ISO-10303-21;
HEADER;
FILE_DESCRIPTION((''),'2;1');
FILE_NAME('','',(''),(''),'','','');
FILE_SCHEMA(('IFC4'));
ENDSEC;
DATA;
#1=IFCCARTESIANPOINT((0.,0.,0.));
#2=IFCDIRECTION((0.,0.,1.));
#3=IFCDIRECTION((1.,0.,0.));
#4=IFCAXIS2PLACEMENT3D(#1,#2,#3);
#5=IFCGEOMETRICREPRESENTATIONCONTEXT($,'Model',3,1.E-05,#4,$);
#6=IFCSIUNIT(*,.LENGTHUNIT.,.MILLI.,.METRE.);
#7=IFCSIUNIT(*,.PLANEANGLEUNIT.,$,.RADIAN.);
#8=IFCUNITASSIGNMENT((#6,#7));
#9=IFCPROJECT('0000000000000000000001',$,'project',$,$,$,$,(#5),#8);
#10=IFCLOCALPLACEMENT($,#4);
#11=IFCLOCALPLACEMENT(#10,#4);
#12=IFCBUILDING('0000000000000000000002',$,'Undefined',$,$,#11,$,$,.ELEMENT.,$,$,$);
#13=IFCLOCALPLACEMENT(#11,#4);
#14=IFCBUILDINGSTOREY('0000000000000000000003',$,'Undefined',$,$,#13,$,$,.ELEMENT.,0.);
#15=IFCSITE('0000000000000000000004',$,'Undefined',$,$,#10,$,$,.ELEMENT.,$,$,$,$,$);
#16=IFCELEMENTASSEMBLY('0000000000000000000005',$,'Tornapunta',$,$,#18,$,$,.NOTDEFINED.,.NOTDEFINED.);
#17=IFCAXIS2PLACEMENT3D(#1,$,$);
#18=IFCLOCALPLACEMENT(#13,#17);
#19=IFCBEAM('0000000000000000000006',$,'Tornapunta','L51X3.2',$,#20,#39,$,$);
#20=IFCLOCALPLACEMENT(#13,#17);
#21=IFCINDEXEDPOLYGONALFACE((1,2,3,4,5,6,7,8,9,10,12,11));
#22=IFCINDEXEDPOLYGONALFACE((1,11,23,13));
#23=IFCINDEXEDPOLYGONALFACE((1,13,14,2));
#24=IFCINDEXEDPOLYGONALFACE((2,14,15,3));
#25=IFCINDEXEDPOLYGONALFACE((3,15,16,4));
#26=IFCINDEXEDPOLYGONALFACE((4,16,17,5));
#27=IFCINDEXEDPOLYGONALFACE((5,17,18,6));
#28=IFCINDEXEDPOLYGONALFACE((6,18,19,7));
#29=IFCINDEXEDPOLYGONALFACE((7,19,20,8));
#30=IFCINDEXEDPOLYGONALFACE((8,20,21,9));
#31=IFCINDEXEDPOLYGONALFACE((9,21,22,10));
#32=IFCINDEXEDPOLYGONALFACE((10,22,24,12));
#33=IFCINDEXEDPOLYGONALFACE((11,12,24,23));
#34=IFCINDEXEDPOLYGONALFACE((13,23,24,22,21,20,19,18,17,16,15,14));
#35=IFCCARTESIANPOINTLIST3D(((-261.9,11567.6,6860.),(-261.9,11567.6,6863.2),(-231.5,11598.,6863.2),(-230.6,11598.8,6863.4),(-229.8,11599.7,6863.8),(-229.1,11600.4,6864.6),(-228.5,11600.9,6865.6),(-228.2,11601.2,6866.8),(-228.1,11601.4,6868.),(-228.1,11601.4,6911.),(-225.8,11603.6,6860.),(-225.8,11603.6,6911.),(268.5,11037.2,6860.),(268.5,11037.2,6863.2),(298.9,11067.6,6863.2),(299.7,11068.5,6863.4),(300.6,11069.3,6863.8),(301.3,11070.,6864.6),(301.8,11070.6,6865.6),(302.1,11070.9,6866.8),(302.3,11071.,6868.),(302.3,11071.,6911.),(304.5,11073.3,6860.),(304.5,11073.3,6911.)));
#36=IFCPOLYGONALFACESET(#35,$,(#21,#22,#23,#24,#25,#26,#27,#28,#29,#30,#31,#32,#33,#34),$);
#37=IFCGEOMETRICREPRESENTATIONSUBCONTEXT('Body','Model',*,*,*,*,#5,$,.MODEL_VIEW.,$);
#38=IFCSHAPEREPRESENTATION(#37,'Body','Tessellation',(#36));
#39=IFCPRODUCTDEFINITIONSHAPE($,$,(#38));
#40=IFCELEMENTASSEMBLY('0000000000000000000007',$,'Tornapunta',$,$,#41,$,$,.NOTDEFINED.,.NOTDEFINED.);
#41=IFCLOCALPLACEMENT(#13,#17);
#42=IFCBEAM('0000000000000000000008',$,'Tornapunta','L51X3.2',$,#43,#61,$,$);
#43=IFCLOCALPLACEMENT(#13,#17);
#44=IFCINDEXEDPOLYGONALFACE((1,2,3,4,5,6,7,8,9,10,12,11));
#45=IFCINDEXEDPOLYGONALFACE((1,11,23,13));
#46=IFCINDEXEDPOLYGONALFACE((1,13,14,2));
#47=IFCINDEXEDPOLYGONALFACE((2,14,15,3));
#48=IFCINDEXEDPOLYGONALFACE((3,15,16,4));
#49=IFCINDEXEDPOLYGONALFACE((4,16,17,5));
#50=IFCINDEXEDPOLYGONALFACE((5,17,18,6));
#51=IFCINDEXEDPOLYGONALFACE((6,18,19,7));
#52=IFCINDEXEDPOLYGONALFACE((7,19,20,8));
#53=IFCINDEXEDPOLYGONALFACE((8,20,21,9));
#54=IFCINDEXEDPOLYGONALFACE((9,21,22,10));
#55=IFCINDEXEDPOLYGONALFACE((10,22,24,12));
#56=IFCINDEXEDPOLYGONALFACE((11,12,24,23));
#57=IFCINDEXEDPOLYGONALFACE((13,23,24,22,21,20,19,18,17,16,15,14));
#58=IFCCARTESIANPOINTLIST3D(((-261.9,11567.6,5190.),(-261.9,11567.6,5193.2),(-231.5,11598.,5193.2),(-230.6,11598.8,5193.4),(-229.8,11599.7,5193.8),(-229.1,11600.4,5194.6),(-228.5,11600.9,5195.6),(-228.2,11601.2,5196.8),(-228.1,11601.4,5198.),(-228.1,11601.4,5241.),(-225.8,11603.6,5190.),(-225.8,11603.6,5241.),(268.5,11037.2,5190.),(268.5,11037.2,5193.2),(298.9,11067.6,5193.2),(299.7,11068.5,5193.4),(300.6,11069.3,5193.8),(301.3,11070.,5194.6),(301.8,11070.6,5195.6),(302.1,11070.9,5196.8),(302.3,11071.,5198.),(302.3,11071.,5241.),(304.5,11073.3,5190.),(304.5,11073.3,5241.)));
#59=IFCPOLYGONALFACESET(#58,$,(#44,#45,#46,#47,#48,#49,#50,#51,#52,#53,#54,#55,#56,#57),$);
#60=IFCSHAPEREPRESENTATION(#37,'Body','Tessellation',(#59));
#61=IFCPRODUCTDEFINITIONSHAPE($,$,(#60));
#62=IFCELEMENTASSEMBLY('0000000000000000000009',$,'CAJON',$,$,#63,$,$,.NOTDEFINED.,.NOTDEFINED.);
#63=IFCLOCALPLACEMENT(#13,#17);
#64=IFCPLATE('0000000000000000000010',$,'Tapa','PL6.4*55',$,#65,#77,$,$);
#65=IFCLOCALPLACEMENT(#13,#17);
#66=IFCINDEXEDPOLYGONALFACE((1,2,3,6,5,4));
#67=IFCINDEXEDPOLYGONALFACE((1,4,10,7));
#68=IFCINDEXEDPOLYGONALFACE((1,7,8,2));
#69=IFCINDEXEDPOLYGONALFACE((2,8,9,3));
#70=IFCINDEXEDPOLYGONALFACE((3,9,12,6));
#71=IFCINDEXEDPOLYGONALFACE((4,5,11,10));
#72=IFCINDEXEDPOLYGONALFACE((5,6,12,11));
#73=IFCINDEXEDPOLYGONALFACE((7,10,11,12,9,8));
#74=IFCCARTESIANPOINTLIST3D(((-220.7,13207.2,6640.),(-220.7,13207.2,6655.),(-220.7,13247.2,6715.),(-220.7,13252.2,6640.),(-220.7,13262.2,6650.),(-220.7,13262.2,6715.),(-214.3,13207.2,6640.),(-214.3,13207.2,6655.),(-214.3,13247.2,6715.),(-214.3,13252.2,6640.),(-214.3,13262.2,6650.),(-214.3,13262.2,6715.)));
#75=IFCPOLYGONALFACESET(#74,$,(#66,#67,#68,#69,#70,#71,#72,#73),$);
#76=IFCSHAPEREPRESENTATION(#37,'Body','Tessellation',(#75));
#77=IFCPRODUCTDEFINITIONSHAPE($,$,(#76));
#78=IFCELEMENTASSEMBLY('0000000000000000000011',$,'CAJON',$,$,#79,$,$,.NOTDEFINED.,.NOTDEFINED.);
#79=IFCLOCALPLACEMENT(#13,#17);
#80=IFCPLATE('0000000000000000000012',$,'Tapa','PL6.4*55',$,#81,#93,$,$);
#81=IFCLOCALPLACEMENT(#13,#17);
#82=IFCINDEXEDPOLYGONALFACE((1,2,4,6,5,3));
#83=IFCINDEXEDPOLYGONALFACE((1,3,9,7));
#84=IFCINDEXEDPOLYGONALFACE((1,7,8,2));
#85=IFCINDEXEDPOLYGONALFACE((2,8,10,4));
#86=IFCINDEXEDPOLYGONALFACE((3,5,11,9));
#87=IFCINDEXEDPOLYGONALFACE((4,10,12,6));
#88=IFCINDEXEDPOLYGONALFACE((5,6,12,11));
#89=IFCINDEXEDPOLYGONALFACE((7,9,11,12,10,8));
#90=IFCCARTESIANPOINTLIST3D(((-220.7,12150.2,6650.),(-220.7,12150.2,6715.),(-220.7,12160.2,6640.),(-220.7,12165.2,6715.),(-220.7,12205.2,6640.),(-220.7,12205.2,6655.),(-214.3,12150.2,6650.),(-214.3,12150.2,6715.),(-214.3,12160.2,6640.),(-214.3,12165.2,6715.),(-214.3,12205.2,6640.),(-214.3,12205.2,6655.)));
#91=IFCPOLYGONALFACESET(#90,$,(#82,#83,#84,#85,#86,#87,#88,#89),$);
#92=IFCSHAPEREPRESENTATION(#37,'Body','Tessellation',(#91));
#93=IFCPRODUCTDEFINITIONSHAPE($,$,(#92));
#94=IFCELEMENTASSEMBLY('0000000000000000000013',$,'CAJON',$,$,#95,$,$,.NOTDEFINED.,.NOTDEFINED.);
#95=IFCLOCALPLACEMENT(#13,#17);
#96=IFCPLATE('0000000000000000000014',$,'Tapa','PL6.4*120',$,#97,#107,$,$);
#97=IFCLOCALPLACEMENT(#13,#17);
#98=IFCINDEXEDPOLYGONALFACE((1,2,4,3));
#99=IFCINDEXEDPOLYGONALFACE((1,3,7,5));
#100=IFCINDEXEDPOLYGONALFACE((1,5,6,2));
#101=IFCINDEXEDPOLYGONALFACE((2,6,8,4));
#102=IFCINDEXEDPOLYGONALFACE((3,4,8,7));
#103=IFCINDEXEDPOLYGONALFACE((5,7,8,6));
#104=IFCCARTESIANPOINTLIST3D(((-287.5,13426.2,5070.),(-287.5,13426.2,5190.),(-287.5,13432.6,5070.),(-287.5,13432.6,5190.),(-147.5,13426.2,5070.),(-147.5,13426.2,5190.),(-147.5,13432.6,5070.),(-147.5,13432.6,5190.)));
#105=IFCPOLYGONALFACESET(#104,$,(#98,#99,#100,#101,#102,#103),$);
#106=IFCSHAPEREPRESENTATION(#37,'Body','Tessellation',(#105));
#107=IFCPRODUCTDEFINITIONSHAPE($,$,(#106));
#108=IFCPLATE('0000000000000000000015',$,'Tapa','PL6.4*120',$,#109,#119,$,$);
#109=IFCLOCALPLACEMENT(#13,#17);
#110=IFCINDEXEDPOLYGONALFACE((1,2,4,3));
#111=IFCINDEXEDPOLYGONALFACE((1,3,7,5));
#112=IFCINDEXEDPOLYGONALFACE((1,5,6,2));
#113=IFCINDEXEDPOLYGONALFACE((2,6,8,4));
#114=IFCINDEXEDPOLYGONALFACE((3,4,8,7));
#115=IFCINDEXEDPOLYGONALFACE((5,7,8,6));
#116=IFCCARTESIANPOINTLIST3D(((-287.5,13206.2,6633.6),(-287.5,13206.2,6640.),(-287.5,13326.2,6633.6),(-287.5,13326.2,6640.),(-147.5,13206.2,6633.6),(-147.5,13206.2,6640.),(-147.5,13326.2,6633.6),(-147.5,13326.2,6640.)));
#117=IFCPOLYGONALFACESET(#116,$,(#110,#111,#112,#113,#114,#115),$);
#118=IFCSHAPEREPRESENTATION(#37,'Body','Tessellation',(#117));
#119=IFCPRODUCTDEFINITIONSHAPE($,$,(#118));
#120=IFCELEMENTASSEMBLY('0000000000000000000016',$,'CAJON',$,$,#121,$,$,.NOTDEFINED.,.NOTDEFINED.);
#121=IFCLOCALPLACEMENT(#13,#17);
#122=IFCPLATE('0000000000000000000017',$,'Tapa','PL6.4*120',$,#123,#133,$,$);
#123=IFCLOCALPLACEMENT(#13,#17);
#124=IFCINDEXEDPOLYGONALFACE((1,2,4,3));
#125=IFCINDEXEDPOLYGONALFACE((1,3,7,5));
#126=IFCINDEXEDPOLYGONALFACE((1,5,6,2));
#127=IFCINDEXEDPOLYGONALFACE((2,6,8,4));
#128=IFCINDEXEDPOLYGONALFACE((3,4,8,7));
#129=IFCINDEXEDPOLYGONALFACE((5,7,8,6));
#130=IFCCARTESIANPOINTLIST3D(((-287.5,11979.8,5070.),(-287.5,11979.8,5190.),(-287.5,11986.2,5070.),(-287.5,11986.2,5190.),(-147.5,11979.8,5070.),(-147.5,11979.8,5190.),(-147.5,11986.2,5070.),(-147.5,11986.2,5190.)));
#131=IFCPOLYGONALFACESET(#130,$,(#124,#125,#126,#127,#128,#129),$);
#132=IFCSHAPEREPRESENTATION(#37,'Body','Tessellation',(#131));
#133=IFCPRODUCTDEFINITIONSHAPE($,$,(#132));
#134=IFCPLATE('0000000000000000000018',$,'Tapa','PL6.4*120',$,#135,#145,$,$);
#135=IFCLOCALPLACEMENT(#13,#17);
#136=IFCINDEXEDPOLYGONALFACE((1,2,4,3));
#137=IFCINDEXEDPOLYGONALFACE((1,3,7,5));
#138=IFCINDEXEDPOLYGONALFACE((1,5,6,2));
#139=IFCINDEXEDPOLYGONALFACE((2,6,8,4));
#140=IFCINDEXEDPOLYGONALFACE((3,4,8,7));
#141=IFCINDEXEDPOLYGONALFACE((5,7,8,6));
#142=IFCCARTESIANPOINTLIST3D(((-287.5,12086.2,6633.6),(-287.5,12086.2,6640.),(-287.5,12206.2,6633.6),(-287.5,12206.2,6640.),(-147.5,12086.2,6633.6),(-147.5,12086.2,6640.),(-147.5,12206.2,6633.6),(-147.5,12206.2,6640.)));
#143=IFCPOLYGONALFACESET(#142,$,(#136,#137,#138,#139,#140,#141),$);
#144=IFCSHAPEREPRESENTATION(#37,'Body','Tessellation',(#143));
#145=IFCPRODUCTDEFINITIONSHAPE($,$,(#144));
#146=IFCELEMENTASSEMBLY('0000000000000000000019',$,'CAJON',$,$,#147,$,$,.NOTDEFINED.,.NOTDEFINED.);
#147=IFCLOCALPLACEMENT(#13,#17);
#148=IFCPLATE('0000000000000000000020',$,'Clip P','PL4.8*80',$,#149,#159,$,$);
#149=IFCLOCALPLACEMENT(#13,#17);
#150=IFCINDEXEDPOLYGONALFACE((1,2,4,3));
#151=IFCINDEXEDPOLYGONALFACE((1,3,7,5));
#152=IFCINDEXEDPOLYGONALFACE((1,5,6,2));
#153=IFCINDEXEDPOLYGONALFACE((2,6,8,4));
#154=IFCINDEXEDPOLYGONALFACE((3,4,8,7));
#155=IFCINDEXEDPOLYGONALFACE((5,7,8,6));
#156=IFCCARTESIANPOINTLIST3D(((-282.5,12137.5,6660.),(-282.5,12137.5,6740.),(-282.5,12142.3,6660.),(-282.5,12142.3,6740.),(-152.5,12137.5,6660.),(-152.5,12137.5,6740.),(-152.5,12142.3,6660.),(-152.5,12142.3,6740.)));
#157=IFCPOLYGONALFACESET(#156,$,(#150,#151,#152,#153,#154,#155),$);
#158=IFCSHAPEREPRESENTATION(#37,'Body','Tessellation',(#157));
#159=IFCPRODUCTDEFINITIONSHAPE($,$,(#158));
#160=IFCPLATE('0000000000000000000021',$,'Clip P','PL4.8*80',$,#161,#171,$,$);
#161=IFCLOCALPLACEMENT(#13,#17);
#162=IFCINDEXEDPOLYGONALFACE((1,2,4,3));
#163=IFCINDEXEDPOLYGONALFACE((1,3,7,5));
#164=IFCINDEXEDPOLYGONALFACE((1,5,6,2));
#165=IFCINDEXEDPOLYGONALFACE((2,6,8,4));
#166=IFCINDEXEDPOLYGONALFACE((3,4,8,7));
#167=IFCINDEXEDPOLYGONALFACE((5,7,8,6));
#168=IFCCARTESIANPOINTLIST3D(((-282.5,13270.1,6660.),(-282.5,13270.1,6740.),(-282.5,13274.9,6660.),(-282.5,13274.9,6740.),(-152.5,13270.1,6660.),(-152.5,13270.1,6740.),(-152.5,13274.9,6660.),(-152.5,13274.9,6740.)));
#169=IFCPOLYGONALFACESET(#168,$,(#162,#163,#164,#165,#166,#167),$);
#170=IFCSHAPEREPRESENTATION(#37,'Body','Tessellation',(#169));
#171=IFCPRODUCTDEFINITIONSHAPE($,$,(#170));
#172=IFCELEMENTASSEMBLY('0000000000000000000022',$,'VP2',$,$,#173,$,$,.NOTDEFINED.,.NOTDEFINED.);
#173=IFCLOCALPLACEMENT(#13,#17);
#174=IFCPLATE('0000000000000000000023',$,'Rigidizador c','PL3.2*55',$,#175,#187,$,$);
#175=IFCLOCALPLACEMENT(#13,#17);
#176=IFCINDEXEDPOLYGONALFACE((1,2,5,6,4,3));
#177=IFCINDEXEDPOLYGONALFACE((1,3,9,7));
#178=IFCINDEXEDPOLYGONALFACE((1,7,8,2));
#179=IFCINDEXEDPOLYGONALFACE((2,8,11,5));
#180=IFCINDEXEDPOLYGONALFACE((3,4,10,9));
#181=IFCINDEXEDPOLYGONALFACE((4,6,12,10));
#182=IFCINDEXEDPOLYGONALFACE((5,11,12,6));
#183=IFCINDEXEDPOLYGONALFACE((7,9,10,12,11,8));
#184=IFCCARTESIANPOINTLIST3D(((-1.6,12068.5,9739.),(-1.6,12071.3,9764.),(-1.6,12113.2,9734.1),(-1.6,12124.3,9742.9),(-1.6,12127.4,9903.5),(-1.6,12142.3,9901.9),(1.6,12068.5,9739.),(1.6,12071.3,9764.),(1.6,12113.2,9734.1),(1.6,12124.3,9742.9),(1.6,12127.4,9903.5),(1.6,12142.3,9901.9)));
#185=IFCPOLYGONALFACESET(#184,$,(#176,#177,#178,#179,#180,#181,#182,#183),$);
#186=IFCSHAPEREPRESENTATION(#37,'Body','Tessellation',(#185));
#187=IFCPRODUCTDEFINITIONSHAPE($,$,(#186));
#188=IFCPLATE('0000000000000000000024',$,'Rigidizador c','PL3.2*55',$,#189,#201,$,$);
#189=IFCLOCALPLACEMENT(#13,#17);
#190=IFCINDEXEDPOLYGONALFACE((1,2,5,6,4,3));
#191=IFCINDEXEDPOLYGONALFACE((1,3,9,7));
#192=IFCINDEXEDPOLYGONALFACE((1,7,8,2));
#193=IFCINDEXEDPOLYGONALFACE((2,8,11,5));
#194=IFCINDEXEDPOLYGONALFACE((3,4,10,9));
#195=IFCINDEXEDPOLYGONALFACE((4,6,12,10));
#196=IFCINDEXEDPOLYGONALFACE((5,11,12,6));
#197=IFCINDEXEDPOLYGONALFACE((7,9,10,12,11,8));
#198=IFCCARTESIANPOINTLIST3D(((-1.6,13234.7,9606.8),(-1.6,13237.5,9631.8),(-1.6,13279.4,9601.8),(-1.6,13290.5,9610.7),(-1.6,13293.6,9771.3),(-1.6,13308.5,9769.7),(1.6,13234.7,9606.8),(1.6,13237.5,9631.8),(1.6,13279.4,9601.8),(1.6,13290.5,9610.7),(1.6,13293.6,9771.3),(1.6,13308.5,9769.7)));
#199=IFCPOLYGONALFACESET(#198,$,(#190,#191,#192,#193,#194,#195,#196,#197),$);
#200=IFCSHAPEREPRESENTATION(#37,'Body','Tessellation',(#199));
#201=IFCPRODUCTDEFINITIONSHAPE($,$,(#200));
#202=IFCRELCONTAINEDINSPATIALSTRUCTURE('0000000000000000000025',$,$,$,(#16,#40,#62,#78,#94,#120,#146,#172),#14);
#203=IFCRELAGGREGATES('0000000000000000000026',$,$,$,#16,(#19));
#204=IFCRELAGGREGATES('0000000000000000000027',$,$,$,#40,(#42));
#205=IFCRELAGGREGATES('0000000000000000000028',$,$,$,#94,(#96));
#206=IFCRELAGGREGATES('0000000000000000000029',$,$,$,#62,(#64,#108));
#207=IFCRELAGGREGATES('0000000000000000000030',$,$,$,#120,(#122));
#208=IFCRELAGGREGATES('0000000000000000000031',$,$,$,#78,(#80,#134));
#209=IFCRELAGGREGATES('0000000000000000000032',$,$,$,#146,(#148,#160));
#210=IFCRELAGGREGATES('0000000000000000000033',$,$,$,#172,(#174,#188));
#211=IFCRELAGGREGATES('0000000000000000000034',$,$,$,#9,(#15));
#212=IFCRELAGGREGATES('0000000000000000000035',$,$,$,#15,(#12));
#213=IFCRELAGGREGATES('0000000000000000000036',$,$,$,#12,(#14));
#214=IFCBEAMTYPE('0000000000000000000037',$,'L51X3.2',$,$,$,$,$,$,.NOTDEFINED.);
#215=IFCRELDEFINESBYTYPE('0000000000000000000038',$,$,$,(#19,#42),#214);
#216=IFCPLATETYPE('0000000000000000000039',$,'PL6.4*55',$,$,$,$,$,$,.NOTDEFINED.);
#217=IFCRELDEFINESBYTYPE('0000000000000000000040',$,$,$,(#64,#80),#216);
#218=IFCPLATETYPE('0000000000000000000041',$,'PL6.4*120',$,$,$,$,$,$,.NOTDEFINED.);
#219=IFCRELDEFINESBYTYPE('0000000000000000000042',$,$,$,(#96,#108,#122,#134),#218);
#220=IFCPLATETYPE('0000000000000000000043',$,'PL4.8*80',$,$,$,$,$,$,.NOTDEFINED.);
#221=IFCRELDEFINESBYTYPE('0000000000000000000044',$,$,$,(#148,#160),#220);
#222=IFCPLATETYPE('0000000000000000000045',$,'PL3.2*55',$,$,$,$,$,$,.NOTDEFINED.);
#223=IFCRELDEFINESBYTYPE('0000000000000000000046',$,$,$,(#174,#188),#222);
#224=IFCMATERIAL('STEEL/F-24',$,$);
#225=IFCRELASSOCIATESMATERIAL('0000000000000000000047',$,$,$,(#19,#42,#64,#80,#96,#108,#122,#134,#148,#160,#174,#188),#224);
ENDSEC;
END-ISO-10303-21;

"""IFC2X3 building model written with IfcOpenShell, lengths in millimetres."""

from ifc_helpers import new_model, si_unit, frame, origin_with_axes, origin_2d_with_axis, place, context, subcontext, project, spatial, polyline, l_section, outline, extrude, material, type_object, element, aggregate, save


model = new_model("IFC2X3")

# Units and contexts
model_context = context("Model", 3, precision=1e-05, world=origin_with_axes())
body_context = subcontext(model_context, "Body", "Model", "MODEL_VIEW")
ifc_project = project(units=[si_unit("LENGTHUNIT", "METRE", prefix="MILLI"), si_unit("PLANEANGLEUNIT", "RADIAN")], contexts=[model_context])

# Site, building, storey
site_placement = place(None, origin_with_axes())
site = spatial("IfcSite", under=ifc_project, at=site_placement, Name="Undefined", CompositionType="ELEMENT")
building_placement = place(site_placement, origin_with_axes())
building = spatial("IfcBuilding", under=site, at=building_placement, Name="Undefined", CompositionType="ELEMENT")
storey_placement = place(building_placement, origin_with_axes())
storey = spatial("IfcBuildingStorey", under=building, at=storey_placement, Name="Undefined", CompositionType="ELEMENT", Elevation=0.0)

# Element assemblies, beams
assembly_1_placement = place(storey_placement, origin_with_axes())
assembly_1 = element("IfcElementAssembly", 1, at=assembly_1_placement, inside=storey, Name="Tornapunta", AssemblyPlace="NOTDEFINED", PredefinedType="NOTDEFINED")
ifc_material_1 = material(Name="STEEL/F-24")
beam_type = type_object("IfcBeamType", Name="L51X3.2", PredefinedType="NOTDEFINED")
beam_1_placement = place(assembly_1_placement, frame((-243.8, 11585.6, 6885.5), z_axis=(0.0, 0.0, 1.0), x_axis=(0.707107, -0.707107, 0.0)))
beam_1 = element("IfcBeam", 2, at=beam_1_placement, type_object=beam_type, material=ifc_material_1, Name="Tornapunta", Description="L51X3.2", context=body_context, shape_type="SweptSolid", body=[
    extrude(l_section(Depth=51.0, Width=51.0, Thickness=3.2, FilletRadius=4.8, at=origin_2d_with_axis()), frame((750.0, 0.0, 0.0), z_axis=(-1.0, 0.0, 0.0), x_axis=(0.0, -1.0, 0.0)), (0.0, 0.0, 1.0), 750.0),
])
aggregate(assembly_1, [beam_1])
assembly_2_placement = place(storey_placement, origin_with_axes())
assembly_2 = element("IfcElementAssembly", 3, at=assembly_2_placement, inside=storey, Name="Tornapunta", AssemblyPlace="NOTDEFINED", PredefinedType="NOTDEFINED")
beam_2_placement = place(assembly_2_placement, frame((-243.8, 11585.6, 5215.5), z_axis=(0.0, 0.0, 1.0), x_axis=(0.707107, -0.707107, 0.0)))
beam_2 = element("IfcBeam", 4, at=beam_2_placement, type_object=beam_type, material=ifc_material_1, Name="Tornapunta", Description="L51X3.2", context=body_context, shape_type="SweptSolid", body=[
    extrude(l_section(Depth=51.0, Width=51.0, Thickness=3.2, FilletRadius=4.8, at=origin_2d_with_axis()), frame((750.0, 0.0, 0.0), z_axis=(-1.0, 0.0, 0.0), x_axis=(0.0, -1.0, 0.0)), (0.0, 0.0, 1.0), 750.0),
])
aggregate(assembly_2, [beam_2])

# Element assemblies, plates
assembly_3_placement = place(storey_placement, origin_with_axes())
assembly_3 = element("IfcElementAssembly", 5, at=assembly_3_placement, inside=storey, Name="CAJON", AssemblyPlace="NOTDEFINED", PredefinedType="NOTDEFINED")
plate_type_1 = type_object("IfcPlateType", Name="PL6.4*55", PredefinedType="NOTDEFINED")
plate_1_placement = place(assembly_3_placement, frame((-217.5, 13262.2, 6715.0), z_axis=(-1.0, 0.0, 0.0), x_axis=(0.0, 0.000064, -1.0)))
plate_1 = element("IfcPlate", 6, at=plate_1_placement, type_object=plate_type_1, material=ifc_material_1, Name="Tapa", Description="PL6.4*55", context=body_context, shape_type="SweptSolid", body=[
    extrude(outline(polyline([(0.0, 0.0), (65.0, 0.0), (75.0, 10.0), (75.0, 55.0), (60.0, 55.0), (0.0, 15.0), (0.0, 0.0)])), frame((0.0, 0.0, -3.2), z_axis=(0.0, 0.0, 1.0), x_axis=(1.0, 0.0, 0.0)), (0.0, 0.0, 1.0), 6.4),
])
assembly_4_placement = place(storey_placement, origin_with_axes())
assembly_4 = element("IfcElementAssembly", 7, at=assembly_4_placement, inside=storey, Name="CAJON", AssemblyPlace="NOTDEFINED", PredefinedType="NOTDEFINED")
plate_2_placement = place(assembly_4_placement, frame((-217.5, 12150.2, 6715.0), z_axis=(1.0, 0.0, 0.0), x_axis=(0.0, -0.000064, -1.0)))
plate_2 = element("IfcPlate", 8, at=plate_2_placement, type_object=plate_type_1, material=ifc_material_1, Name="Tapa", Description="PL6.4*55", context=body_context, shape_type="SweptSolid", body=[
    extrude(outline(polyline([(0.0, 0.0), (65.0, 0.0), (75.0, 10.0), (75.0, 55.0), (60.0, 55.0), (0.0, 15.0), (0.0, 0.0)])), frame((0.0, 0.0, -3.2), z_axis=(0.0, 0.0, 1.0), x_axis=(1.0, 0.0, 0.0)), (0.0, 0.0, 1.0), 6.4),
])
assembly_5_placement = place(storey_placement, origin_with_axes())
assembly_5 = element("IfcElementAssembly", 9, at=assembly_5_placement, inside=storey, Name="CAJON", AssemblyPlace="NOTDEFINED", PredefinedType="NOTDEFINED")
plate_type_2 = type_object("IfcPlateType", Name="PL6.4*120", PredefinedType="NOTDEFINED")
plate_3_placement = place(assembly_5_placement, frame((-287.5, 13429.4, 5190.0), z_axis=(0.0, -1.0, 0.0), x_axis=(0.0, 0.0, -1.0)))
plate_3 = element("IfcPlate", 10, at=plate_3_placement, type_object=plate_type_2, material=ifc_material_1, Name="Tapa", Description="PL6.4*120", context=body_context, shape_type="SweptSolid", body=[
    extrude(outline(polyline([(0.0, 0.0), (120.0, 0.0), (120.0, 140.0), (0.0, 140.0), (0.0, 0.0)])), frame((0.0, 0.0, -3.2), z_axis=(0.0, 0.0, 1.0), x_axis=(1.0, 0.0, 0.0)), (0.0, 0.0, 1.0), 6.4),
])
aggregate(assembly_5, [plate_3])

# Plate
plate_4_placement = place(assembly_3_placement, frame((-287.5, 13206.2, 6636.8), z_axis=(0.0, 0.000039, -1.0), x_axis=(0.0, 1.0, 0.000039)))
plate_4 = element("IfcPlate", 11, at=plate_4_placement, type_object=plate_type_2, material=ifc_material_1, Name="Tapa", Description="PL6.4*120", context=body_context, shape_type="SweptSolid", body=[
    extrude(outline(polyline([(0.0, 0.0), (120.0, 0.0), (120.0, 140.0), (0.0, 140.0), (0.0, 0.0)])), frame((0.0, 0.0, -3.2), z_axis=(0.0, 0.0, 1.0), x_axis=(1.0, 0.0, 0.0)), (0.0, 0.0, 1.0), 6.4),
])
aggregate(assembly_3, [plate_1, plate_4])

# Element assembly, plate
assembly_6_placement = place(storey_placement, origin_with_axes())
assembly_6 = element("IfcElementAssembly", 12, at=assembly_6_placement, inside=storey, Name="CAJON", AssemblyPlace="NOTDEFINED", PredefinedType="NOTDEFINED")
plate_5_placement = place(assembly_6_placement, frame((-287.5, 11983.0, 5190.0), z_axis=(0.0, -1.0, 0.0), x_axis=(0.0, 0.0, -1.0)))
plate_5 = element("IfcPlate", 13, at=plate_5_placement, type_object=plate_type_2, material=ifc_material_1, Name="Tapa", Description="PL6.4*120", context=body_context, shape_type="SweptSolid", body=[
    extrude(outline(polyline([(0.0, 0.0), (120.0, 0.0), (120.0, 140.0), (0.0, 140.0), (0.0, 0.0)])), frame((0.0, 0.0, -3.2), z_axis=(0.0, 0.0, 1.0), x_axis=(1.0, 0.0, 0.0)), (0.0, 0.0, 1.0), 6.4),
])
aggregate(assembly_6, [plate_5])

# Plate
plate_6_placement = place(assembly_4_placement, frame((-287.5, 12206.2, 6636.8), z_axis=(0.0, 0.000039, 1.0), x_axis=(0.0, -1.0, 0.000039)))
plate_6 = element("IfcPlate", 14, at=plate_6_placement, type_object=plate_type_2, material=ifc_material_1, Name="Tapa", Description="PL6.4*120", context=body_context, shape_type="SweptSolid", body=[
    extrude(outline(polyline([(0.0, 0.0), (120.0, 0.0), (120.0, 140.0), (0.0, 140.0), (0.0, 0.0)])), frame((0.0, 0.0, -3.2), z_axis=(0.0, 0.0, 1.0), x_axis=(1.0, 0.0, 0.0)), (0.0, 0.0, 1.0), 6.4),
])
aggregate(assembly_4, [plate_2, plate_6])

# Element assemblies, plates
assembly_7_placement = place(storey_placement, origin_with_axes())
assembly_7 = element("IfcElementAssembly", 15, at=assembly_7_placement, inside=storey, Name="CAJON", AssemblyPlace="NOTDEFINED", PredefinedType="NOTDEFINED")
plate_type_3 = type_object("IfcPlateType", Name="PL4.8*80", PredefinedType="NOTDEFINED")
plate_7_placement = place(assembly_7_placement, frame((-152.5, 12139.9, 6660.0), z_axis=(0.0, 1.0, -0.000052), x_axis=(-1.0, 0.0, 0.0)))
plate_7 = element("IfcPlate", 16, at=plate_7_placement, type_object=plate_type_3, material=ifc_material_1, Name="Clip P", Description="PL4.8*80", context=body_context, shape_type="SweptSolid", body=[
    extrude(outline(polyline([(0.0, 0.0), (130.0, 0.0), (130.0, 80.0), (0.0, 80.0), (0.0, 0.0)])), frame((0.0, 0.0, -2.4), z_axis=(0.0, 0.0, 1.0), x_axis=(1.0, 0.0, 0.0)), (0.0, 0.0, 1.0), 4.8),
])
plate_8_placement = place(assembly_7_placement, frame((-152.5, 13272.5, 6660.0), z_axis=(0.0, 1.0, 0.000052), x_axis=(-1.0, 0.0, 0.0)))
plate_8 = element("IfcPlate", 17, at=plate_8_placement, type_object=plate_type_3, material=ifc_material_1, Name="Clip P", Description="PL4.8*80", context=body_context, shape_type="SweptSolid", body=[
    extrude(outline(polyline([(0.0, 0.0), (130.0, 0.0), (130.0, 80.0), (0.0, 80.0), (0.0, 0.0)])), frame((0.0, 0.0, -2.4), z_axis=(0.0, 0.0, 1.0), x_axis=(1.0, 0.0, 0.0)), (0.0, 0.0, 1.0), 4.8),
])
assembly_8_placement = place(storey_placement, origin_with_axes())
assembly_8 = element("IfcElementAssembly", 18, at=assembly_8_placement, inside=storey, Name="VP2", AssemblyPlace="NOTDEFINED", PredefinedType="NOTDEFINED")
plate_type_4 = type_object("IfcPlateType", Name="PL3.2*55", PredefinedType="NOTDEFINED")
plate_9_placement = place(assembly_8_placement, frame((0.0, 12142.3, 9901.9), z_axis=(1.0, 0.0, 0.0), x_axis=(0.0, -0.993635, 0.112644)))
plate_9 = element("IfcPlate", 19, at=plate_9_placement, type_object=plate_type_4, material=ifc_material_1, Name="Rigidizador c", Description="PL3.2*55", context=body_context, shape_type="SweptSolid", body=[
    extrude(outline(polyline([(0.0, 0.0), (15.0, 0.0), (55.0, 145.0), (55.0, 170.1), (10.0, 170.0), (0.0, 160.0), (0.0, 0.0)])), frame((0.0, 0.0, -1.6), z_axis=(0.0, 0.0, 1.0), x_axis=(1.0, 0.0, 0.0)), (0.0, 0.0, 1.0), 3.2),
])
plate_10_placement = place(assembly_8_placement, frame((0.0, 13308.5, 9769.7), z_axis=(1.0, 0.0, 0.0), x_axis=(0.0, -0.993635, 0.112644)))
plate_10 = element("IfcPlate", 20, at=plate_10_placement, type_object=plate_type_4, material=ifc_material_1, Name="Rigidizador c", Description="PL3.2*55", context=body_context, shape_type="SweptSolid", body=[
    extrude(outline(polyline([(0.0, 0.0), (15.0, 0.0), (55.0, 145.0), (55.0, 170.1), (10.0, 170.0), (0.0, 160.0), (0.0, 0.0)])), frame((0.0, 0.0, -1.6), z_axis=(0.0, 0.0, 1.0), x_axis=(1.0, 0.0, 0.0)), (0.0, 0.0, 1.0), 3.2),
])

aggregate(assembly_7, [plate_7, plate_8])

aggregate(assembly_8, [plate_9, plate_10])

save(model, "model.ifc")
